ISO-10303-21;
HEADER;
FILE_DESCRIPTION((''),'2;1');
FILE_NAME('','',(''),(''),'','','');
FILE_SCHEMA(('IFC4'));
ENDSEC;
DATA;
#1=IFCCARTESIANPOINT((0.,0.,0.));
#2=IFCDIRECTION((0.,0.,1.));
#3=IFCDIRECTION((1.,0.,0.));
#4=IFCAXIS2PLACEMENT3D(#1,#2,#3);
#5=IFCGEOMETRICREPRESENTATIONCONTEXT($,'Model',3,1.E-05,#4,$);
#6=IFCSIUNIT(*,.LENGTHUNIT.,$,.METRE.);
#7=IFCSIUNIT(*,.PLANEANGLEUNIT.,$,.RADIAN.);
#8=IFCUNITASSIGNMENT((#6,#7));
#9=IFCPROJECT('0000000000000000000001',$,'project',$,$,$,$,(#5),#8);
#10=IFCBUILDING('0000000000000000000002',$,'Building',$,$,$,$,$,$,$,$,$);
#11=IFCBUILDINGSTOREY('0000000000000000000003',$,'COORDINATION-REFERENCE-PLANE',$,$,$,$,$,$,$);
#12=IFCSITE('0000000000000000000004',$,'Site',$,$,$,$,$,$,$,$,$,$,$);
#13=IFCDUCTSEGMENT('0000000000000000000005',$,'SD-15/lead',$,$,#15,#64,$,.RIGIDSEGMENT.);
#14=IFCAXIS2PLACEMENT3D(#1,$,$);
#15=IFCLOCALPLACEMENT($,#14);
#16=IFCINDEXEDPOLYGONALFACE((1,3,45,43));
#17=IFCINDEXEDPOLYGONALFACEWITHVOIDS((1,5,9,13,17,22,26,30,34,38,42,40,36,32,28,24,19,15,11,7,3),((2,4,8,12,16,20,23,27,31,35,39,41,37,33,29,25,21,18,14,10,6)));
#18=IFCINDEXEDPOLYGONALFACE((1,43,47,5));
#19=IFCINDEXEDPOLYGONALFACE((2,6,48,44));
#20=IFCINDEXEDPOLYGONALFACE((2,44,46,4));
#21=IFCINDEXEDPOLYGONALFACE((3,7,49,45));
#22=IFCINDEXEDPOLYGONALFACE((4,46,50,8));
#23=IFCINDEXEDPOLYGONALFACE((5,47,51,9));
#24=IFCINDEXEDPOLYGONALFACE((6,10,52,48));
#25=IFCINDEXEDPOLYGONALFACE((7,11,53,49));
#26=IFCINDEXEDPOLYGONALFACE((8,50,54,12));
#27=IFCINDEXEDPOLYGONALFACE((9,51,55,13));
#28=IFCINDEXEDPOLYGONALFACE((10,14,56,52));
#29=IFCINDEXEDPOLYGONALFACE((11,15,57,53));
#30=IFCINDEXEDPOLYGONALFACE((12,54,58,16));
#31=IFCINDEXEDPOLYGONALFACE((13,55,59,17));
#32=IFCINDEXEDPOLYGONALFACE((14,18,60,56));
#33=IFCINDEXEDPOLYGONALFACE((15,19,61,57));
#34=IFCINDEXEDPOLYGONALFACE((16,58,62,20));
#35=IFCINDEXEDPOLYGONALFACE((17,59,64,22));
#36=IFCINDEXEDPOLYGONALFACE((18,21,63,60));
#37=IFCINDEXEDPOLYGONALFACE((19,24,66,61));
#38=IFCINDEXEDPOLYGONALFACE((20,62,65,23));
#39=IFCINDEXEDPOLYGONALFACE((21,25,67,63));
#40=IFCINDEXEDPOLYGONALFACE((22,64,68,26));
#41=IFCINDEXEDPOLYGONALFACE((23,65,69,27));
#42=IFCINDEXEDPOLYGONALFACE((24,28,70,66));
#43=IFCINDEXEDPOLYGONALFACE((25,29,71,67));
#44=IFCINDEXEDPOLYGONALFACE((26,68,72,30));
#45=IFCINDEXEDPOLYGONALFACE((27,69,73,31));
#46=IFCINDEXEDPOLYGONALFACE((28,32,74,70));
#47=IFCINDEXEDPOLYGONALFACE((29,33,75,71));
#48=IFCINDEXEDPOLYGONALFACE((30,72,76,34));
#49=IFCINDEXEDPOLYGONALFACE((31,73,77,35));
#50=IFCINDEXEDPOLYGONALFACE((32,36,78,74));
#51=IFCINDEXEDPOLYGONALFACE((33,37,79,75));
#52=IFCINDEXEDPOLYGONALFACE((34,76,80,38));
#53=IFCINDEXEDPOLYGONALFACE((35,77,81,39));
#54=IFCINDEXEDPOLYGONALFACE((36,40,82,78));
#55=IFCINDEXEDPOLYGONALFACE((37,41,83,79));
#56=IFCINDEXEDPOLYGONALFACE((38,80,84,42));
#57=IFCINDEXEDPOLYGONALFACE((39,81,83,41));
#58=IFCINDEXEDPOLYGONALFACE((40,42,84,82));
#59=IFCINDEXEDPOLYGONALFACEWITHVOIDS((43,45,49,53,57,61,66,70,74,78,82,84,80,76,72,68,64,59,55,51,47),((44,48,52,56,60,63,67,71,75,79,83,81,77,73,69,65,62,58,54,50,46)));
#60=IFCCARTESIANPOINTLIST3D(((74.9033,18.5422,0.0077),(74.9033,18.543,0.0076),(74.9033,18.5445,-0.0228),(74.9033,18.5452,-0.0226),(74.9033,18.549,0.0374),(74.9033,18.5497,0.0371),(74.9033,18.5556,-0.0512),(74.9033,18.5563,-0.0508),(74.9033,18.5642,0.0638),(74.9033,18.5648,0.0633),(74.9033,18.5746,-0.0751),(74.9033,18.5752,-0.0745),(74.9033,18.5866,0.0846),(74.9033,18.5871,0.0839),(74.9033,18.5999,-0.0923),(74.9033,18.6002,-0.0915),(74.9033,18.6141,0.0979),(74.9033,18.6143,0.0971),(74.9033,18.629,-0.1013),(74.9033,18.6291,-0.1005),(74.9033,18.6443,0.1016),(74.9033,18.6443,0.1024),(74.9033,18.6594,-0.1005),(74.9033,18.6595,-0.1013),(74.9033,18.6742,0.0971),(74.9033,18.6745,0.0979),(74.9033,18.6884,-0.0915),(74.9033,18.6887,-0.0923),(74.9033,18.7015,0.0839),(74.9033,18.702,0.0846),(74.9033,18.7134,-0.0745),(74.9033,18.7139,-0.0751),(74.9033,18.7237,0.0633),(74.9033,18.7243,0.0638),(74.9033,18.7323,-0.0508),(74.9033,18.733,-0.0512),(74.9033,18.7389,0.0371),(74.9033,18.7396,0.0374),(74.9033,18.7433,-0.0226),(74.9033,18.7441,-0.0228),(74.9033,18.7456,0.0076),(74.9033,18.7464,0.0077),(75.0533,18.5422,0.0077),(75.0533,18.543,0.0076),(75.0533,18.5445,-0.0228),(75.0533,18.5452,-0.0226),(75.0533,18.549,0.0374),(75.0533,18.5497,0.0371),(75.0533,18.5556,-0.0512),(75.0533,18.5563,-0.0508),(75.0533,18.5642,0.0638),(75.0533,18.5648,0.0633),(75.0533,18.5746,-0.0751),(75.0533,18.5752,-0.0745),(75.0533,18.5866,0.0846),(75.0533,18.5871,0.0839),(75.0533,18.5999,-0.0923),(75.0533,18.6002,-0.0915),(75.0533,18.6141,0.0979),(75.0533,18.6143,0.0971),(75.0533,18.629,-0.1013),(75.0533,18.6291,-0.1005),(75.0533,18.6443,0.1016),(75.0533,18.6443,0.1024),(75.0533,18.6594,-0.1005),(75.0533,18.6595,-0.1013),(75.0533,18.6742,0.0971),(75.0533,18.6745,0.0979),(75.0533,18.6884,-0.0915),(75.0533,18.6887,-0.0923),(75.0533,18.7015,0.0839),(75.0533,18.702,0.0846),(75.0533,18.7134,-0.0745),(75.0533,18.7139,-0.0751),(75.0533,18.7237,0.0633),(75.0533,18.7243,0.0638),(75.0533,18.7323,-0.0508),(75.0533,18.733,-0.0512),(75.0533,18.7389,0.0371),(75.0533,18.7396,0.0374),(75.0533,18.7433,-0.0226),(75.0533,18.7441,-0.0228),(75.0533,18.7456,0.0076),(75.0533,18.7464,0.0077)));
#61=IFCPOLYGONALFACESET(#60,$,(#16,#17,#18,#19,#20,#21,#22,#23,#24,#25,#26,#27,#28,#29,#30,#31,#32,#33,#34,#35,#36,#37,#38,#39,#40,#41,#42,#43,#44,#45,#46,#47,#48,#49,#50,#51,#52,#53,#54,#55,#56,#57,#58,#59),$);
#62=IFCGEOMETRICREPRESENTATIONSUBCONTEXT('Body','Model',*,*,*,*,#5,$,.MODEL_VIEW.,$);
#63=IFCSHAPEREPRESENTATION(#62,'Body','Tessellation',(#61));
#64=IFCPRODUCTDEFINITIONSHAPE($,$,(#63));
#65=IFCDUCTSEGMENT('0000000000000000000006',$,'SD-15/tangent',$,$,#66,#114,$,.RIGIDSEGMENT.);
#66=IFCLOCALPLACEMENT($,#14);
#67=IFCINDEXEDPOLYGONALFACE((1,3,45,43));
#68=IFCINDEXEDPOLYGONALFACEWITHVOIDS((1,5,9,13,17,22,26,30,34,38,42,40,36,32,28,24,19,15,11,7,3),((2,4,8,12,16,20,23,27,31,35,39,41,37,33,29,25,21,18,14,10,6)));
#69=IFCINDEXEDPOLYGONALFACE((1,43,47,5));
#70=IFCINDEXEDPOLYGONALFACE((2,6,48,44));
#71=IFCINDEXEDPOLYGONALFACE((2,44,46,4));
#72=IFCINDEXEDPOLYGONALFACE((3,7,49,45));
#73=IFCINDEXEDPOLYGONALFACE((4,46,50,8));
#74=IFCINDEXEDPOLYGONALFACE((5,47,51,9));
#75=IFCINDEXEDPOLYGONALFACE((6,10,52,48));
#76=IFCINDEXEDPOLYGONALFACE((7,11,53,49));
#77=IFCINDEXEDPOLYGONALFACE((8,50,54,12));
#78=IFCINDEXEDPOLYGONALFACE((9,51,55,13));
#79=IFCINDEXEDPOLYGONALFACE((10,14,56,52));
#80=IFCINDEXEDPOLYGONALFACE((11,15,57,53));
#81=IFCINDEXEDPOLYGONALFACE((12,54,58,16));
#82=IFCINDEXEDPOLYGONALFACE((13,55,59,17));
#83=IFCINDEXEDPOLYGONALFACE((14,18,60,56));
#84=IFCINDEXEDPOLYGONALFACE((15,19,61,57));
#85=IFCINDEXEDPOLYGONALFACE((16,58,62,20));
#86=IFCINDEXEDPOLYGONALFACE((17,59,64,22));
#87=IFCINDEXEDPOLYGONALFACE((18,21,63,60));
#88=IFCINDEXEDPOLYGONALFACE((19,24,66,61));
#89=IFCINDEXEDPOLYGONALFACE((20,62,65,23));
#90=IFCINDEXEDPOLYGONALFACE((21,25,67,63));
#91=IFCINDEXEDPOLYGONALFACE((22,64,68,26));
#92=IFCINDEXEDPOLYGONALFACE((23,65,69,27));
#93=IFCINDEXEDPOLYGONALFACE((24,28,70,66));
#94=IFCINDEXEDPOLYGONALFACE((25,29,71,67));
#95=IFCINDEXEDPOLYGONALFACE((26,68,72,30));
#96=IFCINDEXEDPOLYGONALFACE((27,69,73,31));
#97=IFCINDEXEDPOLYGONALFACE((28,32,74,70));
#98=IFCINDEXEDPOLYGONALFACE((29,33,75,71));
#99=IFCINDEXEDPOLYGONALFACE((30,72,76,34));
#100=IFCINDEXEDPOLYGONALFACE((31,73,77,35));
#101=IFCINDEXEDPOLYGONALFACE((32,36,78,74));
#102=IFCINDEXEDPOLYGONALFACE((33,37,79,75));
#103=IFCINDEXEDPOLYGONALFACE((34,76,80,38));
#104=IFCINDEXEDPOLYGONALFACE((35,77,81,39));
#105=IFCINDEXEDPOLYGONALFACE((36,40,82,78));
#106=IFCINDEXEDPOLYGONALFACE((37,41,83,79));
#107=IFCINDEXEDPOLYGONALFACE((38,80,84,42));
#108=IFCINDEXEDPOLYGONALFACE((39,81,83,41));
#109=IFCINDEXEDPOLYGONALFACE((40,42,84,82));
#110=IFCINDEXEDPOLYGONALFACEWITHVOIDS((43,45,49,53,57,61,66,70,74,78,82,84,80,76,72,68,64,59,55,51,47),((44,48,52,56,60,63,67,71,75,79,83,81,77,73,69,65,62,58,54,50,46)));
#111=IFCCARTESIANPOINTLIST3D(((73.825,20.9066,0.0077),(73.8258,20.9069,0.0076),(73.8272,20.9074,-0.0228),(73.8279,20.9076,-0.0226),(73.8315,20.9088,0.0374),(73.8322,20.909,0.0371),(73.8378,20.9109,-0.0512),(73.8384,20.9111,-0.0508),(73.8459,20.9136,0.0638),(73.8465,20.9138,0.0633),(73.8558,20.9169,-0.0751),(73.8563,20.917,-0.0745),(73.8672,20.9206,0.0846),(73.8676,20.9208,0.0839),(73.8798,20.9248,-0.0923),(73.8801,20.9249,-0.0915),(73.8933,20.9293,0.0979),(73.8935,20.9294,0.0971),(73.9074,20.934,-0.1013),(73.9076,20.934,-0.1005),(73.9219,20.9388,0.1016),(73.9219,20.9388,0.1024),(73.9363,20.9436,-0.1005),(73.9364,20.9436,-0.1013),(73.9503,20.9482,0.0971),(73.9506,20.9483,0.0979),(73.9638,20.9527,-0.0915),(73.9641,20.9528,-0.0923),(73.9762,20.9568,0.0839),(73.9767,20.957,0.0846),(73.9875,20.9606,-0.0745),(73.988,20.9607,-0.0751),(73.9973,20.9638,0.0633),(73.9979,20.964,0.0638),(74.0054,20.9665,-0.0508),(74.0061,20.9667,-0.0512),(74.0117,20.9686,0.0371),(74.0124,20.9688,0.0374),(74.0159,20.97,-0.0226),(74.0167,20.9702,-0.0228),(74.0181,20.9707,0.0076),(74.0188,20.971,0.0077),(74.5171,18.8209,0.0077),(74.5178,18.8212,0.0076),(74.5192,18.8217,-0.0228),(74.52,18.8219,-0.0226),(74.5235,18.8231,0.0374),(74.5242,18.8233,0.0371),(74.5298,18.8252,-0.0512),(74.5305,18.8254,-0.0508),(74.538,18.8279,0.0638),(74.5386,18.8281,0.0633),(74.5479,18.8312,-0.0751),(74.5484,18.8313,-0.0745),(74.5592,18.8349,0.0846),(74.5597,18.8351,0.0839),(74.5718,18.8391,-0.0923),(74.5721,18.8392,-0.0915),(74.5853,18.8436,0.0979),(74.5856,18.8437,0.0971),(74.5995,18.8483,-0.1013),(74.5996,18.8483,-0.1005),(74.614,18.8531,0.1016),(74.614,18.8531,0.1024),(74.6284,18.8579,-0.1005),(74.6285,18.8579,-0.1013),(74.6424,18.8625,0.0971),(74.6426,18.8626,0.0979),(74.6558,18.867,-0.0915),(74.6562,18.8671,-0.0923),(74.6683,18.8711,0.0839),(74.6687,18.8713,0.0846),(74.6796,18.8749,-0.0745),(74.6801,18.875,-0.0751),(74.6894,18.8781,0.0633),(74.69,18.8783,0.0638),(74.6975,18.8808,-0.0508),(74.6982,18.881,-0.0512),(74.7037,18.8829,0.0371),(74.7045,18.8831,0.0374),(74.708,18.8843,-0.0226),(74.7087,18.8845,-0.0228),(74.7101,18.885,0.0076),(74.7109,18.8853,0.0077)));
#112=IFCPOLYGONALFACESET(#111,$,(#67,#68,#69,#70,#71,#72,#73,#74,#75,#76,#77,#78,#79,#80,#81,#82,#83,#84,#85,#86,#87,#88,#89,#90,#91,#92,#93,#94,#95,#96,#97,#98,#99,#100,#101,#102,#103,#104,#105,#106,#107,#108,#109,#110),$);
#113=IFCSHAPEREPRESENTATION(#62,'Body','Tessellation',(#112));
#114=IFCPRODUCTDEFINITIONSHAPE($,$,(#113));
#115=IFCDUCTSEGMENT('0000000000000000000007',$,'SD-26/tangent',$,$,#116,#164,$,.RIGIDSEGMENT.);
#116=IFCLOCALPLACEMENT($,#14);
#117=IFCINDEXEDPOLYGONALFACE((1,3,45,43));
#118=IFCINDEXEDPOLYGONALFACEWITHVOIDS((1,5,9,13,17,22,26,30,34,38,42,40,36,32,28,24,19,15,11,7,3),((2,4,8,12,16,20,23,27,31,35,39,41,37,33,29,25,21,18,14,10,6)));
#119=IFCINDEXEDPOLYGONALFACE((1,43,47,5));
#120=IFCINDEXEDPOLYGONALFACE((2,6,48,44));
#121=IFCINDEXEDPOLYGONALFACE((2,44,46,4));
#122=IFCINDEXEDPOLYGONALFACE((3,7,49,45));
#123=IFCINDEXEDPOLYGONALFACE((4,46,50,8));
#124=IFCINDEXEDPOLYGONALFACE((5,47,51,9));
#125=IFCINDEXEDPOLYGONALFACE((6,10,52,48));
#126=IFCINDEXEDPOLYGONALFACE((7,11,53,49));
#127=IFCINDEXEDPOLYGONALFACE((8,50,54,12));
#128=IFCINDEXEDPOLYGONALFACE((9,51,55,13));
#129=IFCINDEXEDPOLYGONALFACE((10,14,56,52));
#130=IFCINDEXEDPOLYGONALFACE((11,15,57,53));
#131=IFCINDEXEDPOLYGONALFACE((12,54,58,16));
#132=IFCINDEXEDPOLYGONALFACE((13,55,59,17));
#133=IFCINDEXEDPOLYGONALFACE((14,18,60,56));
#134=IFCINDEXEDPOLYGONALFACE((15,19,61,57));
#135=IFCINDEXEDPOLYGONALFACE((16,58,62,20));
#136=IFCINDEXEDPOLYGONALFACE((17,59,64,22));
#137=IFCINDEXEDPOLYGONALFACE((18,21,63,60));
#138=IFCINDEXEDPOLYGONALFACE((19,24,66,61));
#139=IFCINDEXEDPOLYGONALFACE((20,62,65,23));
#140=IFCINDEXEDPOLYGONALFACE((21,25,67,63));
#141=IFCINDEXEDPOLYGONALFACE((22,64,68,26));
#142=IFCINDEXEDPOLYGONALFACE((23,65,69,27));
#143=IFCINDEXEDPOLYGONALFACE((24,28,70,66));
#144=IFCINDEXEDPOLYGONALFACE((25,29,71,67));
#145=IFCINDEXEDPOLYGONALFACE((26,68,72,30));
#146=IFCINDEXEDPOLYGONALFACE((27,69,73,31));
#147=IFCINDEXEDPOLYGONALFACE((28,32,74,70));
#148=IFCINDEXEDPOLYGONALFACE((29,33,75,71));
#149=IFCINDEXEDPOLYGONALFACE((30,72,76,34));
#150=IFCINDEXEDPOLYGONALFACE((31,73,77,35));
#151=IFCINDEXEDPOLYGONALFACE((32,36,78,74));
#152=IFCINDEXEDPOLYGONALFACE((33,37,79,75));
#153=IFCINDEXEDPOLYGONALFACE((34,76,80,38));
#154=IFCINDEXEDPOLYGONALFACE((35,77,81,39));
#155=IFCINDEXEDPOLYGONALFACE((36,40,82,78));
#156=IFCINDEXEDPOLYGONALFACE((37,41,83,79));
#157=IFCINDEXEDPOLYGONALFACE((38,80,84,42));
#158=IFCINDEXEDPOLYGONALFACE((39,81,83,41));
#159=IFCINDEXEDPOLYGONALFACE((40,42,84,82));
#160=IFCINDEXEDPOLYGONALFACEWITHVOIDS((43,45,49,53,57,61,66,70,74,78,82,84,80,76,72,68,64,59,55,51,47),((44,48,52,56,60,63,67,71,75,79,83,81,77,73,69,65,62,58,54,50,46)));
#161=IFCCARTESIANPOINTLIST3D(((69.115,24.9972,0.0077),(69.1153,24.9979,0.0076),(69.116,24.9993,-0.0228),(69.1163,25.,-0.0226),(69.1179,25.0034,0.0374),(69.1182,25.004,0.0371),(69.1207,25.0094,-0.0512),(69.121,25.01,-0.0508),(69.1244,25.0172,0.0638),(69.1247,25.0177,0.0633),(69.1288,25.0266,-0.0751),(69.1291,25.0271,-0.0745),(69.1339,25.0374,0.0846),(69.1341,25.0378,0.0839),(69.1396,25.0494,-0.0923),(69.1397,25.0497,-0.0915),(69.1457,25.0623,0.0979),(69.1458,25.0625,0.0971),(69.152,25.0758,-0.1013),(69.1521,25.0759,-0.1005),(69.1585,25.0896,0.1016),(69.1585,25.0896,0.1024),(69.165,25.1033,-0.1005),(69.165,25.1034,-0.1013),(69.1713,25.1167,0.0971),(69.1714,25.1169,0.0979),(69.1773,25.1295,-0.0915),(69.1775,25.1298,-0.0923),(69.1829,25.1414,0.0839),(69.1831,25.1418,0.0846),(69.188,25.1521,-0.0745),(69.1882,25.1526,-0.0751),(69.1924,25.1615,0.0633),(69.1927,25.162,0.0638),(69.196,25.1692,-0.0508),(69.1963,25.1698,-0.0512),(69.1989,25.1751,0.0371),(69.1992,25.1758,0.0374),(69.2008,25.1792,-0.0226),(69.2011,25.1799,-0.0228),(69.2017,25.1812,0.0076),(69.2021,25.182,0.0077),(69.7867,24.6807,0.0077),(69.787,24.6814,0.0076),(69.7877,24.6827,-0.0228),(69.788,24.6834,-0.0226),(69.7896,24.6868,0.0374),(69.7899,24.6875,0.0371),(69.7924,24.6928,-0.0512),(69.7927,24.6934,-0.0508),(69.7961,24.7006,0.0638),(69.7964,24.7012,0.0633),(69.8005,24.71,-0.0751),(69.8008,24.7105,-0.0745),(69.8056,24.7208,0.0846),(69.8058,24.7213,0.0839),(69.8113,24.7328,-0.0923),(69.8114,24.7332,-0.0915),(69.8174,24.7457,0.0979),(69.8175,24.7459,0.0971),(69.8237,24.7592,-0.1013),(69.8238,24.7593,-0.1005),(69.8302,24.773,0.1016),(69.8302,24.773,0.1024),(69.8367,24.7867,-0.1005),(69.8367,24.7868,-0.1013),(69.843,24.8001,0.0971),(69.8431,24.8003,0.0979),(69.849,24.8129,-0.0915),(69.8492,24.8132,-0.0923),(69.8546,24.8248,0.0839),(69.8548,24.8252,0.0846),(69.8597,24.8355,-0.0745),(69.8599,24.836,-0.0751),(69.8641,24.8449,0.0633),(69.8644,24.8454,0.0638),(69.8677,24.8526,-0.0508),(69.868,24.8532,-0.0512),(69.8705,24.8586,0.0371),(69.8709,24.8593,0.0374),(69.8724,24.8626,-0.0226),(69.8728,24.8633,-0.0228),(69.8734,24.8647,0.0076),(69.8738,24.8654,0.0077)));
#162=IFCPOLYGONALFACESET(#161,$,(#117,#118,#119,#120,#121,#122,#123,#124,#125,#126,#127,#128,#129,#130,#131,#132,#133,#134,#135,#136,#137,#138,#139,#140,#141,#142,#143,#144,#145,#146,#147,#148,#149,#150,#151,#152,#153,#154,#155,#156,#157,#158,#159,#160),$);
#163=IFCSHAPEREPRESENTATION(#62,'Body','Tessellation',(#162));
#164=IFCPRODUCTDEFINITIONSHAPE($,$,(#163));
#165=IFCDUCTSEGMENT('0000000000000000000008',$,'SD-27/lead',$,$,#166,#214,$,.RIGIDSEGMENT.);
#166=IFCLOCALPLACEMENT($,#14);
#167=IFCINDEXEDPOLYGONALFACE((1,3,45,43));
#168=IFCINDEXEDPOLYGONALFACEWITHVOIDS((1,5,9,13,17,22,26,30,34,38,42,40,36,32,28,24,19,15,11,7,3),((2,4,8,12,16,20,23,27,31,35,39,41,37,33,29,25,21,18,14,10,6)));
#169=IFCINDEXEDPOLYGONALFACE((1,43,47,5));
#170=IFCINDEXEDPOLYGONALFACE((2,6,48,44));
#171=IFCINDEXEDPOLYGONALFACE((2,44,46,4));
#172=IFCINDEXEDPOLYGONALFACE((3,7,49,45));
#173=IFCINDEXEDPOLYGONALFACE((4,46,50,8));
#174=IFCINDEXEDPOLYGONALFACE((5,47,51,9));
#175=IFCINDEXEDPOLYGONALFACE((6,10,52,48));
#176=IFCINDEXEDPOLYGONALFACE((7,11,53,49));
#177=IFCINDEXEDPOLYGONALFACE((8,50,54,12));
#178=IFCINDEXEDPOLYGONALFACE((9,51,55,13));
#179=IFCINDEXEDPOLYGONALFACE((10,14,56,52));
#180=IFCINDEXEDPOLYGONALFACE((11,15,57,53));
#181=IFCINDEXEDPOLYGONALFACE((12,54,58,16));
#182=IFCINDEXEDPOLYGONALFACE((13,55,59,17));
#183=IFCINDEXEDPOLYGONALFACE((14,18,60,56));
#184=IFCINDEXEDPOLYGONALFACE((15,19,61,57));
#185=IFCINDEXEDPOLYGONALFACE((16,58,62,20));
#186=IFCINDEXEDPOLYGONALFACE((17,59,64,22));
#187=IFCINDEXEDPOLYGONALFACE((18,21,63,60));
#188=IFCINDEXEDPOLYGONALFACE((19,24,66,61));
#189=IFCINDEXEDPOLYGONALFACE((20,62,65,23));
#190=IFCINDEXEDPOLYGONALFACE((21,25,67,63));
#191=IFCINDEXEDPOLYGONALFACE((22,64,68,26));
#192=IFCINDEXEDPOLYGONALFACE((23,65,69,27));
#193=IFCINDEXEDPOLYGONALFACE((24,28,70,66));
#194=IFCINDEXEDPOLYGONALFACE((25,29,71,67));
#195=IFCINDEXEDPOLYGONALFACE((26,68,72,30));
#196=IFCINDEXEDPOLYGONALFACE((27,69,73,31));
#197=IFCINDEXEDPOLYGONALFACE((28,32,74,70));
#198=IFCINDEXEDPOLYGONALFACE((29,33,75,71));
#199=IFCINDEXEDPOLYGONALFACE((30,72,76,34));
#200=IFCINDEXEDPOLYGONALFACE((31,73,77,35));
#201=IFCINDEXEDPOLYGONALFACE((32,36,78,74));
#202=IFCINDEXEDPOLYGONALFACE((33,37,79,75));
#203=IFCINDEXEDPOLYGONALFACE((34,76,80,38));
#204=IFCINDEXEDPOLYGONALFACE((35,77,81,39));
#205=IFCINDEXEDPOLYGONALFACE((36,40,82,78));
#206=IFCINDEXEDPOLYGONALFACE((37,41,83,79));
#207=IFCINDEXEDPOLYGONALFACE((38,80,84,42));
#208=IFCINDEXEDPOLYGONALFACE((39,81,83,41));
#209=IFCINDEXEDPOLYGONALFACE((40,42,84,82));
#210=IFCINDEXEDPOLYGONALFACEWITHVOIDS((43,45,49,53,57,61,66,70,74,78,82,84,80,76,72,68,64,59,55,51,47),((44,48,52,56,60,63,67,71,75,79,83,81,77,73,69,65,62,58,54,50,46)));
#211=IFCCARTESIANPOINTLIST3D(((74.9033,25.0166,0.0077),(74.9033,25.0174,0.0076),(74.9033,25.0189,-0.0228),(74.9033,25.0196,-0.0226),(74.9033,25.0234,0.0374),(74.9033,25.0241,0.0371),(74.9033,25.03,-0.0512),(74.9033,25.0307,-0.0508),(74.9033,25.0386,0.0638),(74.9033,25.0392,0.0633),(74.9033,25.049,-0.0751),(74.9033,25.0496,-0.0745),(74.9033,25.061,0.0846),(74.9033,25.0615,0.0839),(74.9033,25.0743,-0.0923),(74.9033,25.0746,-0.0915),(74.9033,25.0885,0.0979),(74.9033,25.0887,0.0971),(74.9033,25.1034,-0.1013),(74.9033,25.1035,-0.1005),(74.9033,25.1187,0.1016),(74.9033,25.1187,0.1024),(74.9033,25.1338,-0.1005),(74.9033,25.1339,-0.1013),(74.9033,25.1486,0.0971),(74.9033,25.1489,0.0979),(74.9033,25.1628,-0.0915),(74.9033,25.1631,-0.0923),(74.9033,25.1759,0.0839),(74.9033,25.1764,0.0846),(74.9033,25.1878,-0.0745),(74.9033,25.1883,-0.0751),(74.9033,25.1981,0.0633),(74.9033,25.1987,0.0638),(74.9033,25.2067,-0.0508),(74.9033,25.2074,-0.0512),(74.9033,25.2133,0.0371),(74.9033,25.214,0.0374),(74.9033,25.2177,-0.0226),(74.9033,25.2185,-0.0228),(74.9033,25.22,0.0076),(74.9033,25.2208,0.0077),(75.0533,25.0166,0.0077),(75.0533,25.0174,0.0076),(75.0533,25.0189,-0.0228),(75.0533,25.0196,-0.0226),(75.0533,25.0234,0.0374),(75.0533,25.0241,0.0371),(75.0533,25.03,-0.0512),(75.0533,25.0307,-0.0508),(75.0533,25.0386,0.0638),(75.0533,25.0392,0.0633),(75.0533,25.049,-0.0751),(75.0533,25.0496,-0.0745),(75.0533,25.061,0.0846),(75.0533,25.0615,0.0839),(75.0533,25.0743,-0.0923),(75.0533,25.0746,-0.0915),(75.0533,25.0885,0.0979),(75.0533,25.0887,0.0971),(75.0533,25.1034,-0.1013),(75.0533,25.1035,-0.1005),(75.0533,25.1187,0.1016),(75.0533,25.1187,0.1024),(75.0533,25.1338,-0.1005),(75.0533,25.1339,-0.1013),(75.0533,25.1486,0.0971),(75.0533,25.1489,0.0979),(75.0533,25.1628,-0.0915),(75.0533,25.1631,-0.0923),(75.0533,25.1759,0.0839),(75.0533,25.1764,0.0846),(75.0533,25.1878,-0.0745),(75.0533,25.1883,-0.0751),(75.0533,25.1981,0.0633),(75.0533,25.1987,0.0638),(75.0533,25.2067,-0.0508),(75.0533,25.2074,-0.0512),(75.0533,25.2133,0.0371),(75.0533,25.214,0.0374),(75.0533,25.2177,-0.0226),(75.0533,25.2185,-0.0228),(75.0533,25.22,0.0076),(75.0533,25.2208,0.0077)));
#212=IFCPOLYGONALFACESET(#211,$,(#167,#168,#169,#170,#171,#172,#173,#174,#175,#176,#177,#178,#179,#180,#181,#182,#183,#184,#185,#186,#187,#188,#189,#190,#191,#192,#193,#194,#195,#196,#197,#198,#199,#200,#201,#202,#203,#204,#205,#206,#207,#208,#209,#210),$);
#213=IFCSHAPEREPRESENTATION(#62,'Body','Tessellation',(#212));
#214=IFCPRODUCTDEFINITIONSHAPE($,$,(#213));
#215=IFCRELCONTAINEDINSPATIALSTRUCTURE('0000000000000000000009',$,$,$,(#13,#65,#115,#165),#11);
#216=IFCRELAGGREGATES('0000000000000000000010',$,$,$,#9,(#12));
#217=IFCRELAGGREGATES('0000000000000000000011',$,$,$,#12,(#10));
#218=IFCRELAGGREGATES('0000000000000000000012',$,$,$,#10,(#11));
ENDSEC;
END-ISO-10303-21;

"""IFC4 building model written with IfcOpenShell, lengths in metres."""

from ifc_helpers import new_model, si_unit, frame, origin_with_axes, place, context, subcontext, project, spatial, hollow_circle, extrude, element, save


model = new_model("IFC4")

# Units and contexts
model_context_1 = context("Model", 3, precision=1e-05, world=origin_with_axes())
body_context_1 = subcontext(model_context_1, "Body", "Model", "MODEL_VIEW")
ifc_project = project(units=[si_unit("LENGTHUNIT", "METRE"), si_unit("PLANEANGLEUNIT", "RADIAN")], contexts=[model_context_1])

# Site, building, storey
site = spatial("IfcSite", under=ifc_project, Name="Site")
building = spatial("IfcBuilding", under=site, Name="Building")
storey = spatial("IfcBuildingStorey", under=building, Name="COORDINATION-REFERENCE-PLANE")

# Duct segment
duct_segment_1_placement = place(None, frame((75.0533, 18.6443, 0.0), z_axis=(-1.0, 0.0, 0.0), x_axis=(0.0, 0.0, 1.0)))
element("IfcDuctSegment", 1, at=duct_segment_1_placement, inside=storey, Name="SD-15/lead", PredefinedType="RIGIDSEGMENT", context=body_context_1, shape_type="SweptSolid", body=[
    extrude(hollow_circle(Radius=0.1024, WallThickness=0.0008), origin_with_axes(), (0.0, 0.0, 1.0), 0.15),
])

# Duct segment
duct_segment_2_placement = place(None, frame((74.614, 18.8531, 0.0), z_axis=(-0.314929, 0.949115, 0.0), x_axis=(0.0, 0.0, 1.0)))
element("IfcDuctSegment", 2, at=duct_segment_2_placement, inside=storey, Name="SD-15/tangent", PredefinedType="RIGIDSEGMENT", context=body_context_1, shape_type="SweptSolid", body=[
    extrude(hollow_circle(Radius=0.1024, WallThickness=0.0008), origin_with_axes(), (0.0, 0.0, 1.0), 2.1975),
])

# Duct segment
duct_segment_3_placement = place(None, frame((69.1585, 25.0896, 0.0), z_axis=(0.904569, -0.426327, 0.0), x_axis=(0.0, 0.0, 1.0)))
element("IfcDuctSegment", 3, at=duct_segment_3_placement, inside=storey, Name="SD-26/tangent", PredefinedType="RIGIDSEGMENT", context=body_context_1, shape_type="SweptSolid", body=[
    extrude(hollow_circle(Radius=0.1024, WallThickness=0.0008), origin_with_axes(), (0.0, 0.0, 1.0), 0.7425),
])

# Duct segment
duct_segment_4_placement = place(None, frame((75.0533, 25.1187, 0.0), z_axis=(-1.0, 0.0, 0.0), x_axis=(0.0, 0.0, 1.0)))
element("IfcDuctSegment", 4, at=duct_segment_4_placement, inside=storey, Name="SD-27/lead", PredefinedType="RIGIDSEGMENT", context=body_context_1, shape_type="SweptSolid", body=[
    extrude(hollow_circle(Radius=0.1024, WallThickness=0.0008), origin_with_axes(), (0.0, 0.0, 1.0), 0.15),
])

save(model, "model.ifc")
